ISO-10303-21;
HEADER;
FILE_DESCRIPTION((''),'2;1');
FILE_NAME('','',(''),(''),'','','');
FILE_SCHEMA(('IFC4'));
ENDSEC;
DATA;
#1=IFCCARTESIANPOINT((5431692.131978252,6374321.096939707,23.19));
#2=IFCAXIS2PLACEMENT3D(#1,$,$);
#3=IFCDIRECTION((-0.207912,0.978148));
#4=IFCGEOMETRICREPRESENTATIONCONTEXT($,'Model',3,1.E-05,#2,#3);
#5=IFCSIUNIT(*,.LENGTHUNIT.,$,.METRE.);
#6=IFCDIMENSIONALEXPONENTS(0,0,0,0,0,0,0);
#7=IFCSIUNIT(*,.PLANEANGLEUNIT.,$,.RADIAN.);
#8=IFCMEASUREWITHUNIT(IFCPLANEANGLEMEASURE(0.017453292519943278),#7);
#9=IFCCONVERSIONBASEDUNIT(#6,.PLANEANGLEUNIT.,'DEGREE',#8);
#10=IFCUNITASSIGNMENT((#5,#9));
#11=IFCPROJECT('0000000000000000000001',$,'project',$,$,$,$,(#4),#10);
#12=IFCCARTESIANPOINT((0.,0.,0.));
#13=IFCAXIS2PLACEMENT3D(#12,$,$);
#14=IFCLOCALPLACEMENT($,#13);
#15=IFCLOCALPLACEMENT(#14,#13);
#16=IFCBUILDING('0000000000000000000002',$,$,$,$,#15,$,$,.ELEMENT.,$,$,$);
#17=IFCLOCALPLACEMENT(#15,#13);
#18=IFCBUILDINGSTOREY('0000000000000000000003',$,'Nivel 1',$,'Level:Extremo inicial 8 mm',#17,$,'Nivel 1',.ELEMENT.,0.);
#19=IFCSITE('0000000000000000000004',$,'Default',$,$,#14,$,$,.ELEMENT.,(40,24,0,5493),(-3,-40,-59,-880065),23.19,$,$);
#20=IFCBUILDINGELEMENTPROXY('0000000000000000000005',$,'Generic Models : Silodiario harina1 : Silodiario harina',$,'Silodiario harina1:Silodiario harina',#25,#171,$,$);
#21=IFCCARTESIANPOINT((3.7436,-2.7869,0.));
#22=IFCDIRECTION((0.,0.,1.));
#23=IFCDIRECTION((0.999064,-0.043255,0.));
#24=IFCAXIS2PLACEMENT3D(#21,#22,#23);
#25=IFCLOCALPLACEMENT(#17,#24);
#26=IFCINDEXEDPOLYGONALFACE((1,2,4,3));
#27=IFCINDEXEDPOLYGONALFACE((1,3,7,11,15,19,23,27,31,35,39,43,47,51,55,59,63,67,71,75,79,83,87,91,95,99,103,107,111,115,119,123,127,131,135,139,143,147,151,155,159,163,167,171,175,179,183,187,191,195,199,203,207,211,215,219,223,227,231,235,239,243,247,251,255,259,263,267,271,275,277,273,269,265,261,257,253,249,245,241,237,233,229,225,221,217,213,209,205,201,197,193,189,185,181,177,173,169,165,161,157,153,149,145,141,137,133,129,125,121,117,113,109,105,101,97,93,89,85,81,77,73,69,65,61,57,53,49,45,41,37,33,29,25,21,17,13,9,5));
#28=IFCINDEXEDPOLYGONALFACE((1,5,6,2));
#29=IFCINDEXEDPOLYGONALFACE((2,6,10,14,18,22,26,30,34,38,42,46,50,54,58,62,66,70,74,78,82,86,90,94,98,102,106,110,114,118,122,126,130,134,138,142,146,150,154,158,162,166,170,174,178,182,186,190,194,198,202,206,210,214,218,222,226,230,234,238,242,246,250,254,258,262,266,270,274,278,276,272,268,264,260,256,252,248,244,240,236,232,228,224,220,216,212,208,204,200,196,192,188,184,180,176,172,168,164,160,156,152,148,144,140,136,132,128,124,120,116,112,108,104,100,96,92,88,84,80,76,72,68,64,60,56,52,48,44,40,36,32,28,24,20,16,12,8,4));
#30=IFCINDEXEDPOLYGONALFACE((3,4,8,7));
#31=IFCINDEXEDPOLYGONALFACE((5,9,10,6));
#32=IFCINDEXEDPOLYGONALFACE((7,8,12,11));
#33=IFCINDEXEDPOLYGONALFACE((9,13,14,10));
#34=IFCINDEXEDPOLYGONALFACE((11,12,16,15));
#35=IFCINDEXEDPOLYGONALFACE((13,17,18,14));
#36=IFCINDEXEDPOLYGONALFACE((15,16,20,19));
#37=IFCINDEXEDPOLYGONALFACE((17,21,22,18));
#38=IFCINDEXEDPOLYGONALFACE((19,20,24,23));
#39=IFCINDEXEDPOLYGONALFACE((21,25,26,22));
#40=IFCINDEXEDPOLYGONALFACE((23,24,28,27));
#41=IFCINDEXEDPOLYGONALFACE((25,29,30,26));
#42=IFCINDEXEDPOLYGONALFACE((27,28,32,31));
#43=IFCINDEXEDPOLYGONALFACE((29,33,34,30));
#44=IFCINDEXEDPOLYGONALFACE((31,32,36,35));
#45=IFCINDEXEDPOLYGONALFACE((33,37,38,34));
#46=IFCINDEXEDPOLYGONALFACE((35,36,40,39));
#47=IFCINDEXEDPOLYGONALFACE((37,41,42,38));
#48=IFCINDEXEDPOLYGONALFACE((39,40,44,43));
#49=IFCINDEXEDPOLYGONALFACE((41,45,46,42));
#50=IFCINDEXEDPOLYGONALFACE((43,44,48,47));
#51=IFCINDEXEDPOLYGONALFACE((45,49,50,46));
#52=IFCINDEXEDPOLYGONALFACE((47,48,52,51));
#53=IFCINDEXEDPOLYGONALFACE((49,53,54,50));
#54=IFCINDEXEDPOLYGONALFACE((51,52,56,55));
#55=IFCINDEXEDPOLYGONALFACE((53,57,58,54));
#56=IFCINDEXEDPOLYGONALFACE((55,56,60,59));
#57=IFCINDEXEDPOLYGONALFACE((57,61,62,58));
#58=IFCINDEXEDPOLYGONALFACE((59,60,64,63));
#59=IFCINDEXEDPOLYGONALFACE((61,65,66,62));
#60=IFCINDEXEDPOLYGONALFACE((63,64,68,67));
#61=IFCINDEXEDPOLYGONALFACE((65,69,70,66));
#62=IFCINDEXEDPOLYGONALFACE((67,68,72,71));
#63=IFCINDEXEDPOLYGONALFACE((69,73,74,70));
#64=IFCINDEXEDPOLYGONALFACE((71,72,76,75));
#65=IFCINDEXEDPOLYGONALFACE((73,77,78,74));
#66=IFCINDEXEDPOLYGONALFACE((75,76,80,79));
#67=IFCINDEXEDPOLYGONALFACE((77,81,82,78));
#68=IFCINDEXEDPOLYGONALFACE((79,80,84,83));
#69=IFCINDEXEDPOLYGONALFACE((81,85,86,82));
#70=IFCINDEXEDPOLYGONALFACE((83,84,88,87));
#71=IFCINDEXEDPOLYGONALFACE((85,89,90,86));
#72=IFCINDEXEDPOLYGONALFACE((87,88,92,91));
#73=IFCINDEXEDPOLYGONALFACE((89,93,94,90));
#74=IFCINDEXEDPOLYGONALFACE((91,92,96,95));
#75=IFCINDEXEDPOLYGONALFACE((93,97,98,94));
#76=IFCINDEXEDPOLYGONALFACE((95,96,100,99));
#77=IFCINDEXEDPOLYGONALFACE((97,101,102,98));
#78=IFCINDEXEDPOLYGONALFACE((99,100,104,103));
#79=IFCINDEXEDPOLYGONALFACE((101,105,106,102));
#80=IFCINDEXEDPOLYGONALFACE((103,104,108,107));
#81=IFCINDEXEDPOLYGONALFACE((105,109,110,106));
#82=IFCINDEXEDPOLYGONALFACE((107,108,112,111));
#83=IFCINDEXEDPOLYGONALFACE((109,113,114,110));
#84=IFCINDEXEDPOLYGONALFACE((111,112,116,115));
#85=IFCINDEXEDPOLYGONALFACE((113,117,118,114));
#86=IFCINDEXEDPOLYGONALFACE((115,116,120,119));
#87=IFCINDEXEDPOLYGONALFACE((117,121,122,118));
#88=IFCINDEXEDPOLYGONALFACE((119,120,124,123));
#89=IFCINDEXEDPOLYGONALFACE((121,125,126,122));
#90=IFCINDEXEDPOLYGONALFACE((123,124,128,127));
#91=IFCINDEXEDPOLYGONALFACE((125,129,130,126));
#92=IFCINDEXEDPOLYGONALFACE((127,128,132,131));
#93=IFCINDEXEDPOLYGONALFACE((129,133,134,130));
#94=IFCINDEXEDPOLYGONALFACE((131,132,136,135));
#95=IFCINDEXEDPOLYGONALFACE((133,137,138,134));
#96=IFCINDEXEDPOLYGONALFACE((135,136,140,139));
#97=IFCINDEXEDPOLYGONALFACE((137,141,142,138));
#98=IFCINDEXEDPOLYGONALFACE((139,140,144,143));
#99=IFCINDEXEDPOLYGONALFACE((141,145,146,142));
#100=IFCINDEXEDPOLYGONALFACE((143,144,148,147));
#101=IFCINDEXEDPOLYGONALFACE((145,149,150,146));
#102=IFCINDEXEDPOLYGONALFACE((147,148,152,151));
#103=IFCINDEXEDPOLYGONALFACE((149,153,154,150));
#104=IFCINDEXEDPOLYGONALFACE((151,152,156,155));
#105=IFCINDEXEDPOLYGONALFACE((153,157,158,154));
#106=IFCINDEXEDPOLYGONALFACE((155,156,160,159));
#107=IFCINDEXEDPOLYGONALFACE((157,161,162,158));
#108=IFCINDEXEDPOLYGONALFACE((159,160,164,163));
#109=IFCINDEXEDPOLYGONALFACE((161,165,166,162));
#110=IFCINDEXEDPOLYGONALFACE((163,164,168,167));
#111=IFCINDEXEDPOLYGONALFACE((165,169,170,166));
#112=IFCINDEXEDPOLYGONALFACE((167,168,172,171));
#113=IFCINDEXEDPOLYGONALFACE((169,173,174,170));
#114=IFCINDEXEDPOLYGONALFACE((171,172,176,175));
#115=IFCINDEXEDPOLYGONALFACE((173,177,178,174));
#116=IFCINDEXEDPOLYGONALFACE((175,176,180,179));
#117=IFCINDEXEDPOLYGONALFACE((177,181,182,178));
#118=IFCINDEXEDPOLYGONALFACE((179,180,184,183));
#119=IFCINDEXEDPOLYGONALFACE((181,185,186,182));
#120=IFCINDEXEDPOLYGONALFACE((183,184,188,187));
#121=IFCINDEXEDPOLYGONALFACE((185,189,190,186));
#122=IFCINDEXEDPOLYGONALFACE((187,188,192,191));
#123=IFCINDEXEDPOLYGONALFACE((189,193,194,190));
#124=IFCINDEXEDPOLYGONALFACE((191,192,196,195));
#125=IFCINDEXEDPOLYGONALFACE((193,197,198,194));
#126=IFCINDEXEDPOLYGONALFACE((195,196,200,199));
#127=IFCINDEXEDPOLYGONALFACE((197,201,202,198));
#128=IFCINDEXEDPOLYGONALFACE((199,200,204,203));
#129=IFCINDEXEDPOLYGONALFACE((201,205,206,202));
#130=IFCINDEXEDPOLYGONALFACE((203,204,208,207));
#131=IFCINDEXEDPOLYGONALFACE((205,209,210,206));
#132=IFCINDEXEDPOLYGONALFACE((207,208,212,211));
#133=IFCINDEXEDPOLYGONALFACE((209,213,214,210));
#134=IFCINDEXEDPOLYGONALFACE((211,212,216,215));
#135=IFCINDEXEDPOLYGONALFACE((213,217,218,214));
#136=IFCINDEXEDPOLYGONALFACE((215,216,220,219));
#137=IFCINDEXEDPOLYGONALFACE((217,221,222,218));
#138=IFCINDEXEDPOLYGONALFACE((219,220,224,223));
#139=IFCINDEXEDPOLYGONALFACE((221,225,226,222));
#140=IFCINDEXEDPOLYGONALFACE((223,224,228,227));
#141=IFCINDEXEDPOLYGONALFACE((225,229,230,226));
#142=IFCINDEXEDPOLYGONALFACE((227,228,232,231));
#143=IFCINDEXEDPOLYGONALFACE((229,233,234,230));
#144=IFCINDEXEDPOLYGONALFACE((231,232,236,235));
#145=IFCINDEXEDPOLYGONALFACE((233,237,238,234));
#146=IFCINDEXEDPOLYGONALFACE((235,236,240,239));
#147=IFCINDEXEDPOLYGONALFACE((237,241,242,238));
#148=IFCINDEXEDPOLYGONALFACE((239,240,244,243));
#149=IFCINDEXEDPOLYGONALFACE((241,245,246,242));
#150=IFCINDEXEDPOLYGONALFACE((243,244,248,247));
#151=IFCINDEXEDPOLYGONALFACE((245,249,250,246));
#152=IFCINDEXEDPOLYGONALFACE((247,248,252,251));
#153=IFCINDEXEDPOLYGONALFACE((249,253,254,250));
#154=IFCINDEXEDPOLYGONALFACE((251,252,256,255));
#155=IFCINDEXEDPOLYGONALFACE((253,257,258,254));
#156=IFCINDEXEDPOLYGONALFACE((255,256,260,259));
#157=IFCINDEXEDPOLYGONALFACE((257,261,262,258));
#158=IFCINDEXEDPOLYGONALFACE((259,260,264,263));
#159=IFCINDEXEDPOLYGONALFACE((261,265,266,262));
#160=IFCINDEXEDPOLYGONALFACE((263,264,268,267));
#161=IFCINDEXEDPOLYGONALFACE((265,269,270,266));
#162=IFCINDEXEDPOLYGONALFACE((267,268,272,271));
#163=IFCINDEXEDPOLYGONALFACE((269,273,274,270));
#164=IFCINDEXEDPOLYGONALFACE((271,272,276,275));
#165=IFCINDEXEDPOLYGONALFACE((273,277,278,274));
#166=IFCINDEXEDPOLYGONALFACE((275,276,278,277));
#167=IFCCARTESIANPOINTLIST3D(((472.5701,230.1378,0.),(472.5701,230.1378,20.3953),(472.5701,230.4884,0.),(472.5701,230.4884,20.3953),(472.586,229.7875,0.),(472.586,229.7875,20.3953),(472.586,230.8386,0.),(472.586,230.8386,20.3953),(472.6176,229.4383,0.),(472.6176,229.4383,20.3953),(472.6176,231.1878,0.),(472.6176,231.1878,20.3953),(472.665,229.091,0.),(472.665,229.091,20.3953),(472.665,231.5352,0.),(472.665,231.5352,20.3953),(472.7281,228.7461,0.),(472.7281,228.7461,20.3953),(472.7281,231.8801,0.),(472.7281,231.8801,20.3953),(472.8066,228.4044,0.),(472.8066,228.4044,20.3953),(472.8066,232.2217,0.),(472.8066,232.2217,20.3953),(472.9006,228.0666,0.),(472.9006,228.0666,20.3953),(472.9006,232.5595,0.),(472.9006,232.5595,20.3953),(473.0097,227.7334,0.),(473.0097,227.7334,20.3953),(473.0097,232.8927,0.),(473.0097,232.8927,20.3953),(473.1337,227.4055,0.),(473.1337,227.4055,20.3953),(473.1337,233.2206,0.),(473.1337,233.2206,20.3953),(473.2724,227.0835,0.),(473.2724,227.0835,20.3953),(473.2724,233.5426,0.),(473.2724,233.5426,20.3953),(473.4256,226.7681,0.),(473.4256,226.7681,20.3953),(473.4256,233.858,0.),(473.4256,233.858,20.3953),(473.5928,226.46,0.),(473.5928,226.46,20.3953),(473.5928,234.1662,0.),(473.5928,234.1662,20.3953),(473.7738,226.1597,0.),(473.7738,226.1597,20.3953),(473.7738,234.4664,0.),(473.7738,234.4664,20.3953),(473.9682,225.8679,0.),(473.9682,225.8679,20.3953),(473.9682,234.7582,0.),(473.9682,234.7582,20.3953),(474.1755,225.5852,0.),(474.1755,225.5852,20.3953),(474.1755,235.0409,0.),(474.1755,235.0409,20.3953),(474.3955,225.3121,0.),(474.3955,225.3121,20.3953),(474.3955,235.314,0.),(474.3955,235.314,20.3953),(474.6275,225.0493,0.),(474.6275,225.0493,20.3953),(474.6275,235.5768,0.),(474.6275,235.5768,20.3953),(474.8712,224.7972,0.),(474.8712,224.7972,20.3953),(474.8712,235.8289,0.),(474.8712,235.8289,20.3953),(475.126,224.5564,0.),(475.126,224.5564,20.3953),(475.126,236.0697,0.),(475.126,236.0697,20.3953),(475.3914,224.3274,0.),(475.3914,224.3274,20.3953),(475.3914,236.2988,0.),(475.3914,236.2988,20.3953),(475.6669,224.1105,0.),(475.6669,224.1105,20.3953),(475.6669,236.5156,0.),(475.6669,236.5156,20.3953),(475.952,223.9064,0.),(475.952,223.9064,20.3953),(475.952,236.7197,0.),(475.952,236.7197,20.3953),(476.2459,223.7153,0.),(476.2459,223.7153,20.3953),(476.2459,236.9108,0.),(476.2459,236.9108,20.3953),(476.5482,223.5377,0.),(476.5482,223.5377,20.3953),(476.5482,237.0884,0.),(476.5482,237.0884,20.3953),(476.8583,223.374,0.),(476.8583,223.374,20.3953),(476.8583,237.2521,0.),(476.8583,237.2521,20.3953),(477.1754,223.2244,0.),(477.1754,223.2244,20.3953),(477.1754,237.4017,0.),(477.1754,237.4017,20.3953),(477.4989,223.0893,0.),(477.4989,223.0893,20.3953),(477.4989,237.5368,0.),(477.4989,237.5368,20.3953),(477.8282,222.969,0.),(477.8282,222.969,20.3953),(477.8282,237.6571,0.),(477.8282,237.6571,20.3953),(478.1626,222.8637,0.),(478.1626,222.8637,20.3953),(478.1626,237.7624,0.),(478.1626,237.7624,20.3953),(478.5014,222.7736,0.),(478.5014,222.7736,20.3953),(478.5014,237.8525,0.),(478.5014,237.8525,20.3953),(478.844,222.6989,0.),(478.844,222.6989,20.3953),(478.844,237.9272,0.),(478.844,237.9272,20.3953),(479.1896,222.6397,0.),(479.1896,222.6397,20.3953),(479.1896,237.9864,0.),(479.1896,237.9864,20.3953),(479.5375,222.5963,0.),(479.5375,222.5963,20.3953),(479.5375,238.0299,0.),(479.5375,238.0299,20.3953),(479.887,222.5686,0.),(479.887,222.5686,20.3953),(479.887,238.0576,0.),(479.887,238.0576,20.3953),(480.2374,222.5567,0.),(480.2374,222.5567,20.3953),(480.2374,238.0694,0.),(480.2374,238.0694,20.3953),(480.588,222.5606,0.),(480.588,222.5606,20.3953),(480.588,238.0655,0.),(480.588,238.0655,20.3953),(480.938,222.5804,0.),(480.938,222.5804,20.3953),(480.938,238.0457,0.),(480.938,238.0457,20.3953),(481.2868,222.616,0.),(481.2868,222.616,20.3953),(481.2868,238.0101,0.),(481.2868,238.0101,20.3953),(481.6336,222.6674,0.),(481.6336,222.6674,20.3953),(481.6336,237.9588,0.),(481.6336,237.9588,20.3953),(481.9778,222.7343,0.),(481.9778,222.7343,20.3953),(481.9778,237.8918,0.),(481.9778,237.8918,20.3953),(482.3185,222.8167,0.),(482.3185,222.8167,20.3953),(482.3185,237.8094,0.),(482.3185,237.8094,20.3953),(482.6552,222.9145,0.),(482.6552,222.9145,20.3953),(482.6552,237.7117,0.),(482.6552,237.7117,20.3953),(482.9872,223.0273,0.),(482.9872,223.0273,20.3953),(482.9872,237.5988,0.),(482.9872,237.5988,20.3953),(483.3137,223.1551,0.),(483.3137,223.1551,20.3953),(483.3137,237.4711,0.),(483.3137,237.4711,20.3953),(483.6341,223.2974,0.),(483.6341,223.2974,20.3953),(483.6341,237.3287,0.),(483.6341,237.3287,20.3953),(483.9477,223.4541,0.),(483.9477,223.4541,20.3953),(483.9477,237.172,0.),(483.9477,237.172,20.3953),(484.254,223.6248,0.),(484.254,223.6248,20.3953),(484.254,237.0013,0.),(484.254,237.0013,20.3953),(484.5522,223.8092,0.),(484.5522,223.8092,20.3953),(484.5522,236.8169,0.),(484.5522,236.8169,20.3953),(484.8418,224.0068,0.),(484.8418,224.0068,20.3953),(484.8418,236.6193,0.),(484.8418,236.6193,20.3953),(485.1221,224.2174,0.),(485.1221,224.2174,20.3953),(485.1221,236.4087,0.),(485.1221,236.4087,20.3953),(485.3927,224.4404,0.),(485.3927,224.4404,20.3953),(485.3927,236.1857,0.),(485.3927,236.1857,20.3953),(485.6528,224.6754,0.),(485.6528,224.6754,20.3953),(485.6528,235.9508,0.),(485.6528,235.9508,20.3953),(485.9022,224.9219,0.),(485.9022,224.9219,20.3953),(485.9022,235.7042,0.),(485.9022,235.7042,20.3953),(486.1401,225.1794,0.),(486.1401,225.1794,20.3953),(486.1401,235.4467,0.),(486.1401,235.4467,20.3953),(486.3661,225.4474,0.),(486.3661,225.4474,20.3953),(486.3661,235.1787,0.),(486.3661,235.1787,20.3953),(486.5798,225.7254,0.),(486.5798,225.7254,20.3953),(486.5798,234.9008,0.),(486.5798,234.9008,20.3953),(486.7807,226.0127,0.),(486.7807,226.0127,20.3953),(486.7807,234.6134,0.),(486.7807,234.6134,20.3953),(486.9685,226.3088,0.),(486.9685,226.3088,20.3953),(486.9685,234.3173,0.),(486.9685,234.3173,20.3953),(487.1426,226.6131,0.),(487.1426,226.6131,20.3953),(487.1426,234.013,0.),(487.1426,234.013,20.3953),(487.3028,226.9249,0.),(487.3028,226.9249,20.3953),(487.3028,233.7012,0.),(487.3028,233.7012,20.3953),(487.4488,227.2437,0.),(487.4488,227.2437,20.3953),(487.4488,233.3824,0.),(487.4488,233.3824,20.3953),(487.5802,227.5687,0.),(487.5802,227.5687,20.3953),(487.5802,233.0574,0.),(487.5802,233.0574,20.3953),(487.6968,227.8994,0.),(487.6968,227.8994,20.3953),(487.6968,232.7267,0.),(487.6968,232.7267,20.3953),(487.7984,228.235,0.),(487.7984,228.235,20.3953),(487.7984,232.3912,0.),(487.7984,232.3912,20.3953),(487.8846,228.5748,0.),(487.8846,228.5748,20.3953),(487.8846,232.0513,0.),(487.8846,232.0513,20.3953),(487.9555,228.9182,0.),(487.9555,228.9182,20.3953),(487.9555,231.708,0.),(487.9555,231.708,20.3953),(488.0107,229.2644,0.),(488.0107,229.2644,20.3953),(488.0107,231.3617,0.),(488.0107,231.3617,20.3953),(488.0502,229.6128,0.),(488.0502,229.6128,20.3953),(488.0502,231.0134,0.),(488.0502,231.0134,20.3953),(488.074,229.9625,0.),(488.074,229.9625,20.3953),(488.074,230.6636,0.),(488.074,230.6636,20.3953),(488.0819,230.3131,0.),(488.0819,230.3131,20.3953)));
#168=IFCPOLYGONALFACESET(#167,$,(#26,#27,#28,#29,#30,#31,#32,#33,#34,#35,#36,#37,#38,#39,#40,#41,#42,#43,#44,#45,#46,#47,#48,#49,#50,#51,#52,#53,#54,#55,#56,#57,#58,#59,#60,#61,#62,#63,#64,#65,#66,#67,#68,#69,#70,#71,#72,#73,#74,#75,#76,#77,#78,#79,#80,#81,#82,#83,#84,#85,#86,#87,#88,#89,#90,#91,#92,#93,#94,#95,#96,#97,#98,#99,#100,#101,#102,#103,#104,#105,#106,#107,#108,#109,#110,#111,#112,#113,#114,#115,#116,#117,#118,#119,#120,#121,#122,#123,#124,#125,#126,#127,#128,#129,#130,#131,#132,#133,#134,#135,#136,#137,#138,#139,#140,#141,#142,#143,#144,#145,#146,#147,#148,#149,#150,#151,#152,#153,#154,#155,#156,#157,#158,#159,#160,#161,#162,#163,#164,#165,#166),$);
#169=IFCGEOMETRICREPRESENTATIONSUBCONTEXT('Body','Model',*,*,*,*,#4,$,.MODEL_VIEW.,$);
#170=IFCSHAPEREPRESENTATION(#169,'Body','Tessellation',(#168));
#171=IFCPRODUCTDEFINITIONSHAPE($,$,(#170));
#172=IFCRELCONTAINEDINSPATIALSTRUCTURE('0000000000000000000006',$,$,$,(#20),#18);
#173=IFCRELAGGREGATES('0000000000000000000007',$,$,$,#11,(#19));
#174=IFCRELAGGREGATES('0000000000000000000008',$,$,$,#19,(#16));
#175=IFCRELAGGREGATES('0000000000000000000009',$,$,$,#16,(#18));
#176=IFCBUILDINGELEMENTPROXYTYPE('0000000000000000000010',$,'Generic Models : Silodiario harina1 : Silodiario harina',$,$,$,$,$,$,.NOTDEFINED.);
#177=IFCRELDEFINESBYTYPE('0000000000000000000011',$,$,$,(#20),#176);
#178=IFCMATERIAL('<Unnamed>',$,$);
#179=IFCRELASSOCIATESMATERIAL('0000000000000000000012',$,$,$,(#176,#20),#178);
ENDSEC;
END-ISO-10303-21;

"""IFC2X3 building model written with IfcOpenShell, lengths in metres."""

from ifc_helpers import new_model, entity, si_unit, converted_unit, direction, frame, origin, origin_2d_with_axis, place, context, subcontext, project, spatial, circle, extrude, source, transform, mapped, material, type_object, type_shapes, element, save


model = new_model("IFC2X3")

# Units and contexts
model_context = context("Model", 3, precision=1e-05, world=frame((5431692.131978252, 6374321.096939707, 23.19)), true_north=direction((-0.207912, 0.978148)))
body_context = subcontext(model_context, "Body", "Model", "MODEL_VIEW")
ifc_project = project(units=[si_unit("LENGTHUNIT", "METRE"), converted_unit("PLANEANGLEUNIT", "DEGREE", entity("IfcPlaneAngleMeasure", 0.017453292519943278), si_unit("PLANEANGLEUNIT", "RADIAN"), dimensions=[0, 0, 0, 0, 0, 0, 0])], contexts=[model_context])

# Site, building, storey
site_placement = place(None, origin())
site = spatial("IfcSite", under=ifc_project, at=site_placement, Name="Default", CompositionType="ELEMENT", RefLatitude=(40, 24, 0, 5493), RefLongitude=(-3, -40, -59, -880065), RefElevation=23.19)
building_placement = place(site_placement, origin())
building = spatial("IfcBuilding", under=site, at=building_placement, CompositionType="ELEMENT")
storey_placement = place(building_placement, origin())
storey = spatial("IfcBuildingStorey", under=building, at=storey_placement, Name="Nivel 1", ObjectType="Level:Extremo inicial 8 mm", LongName="Nivel 1", CompositionType="ELEMENT", Elevation=0.0)

# Building element proxy
ifc_material_1 = material(Name="<Unnamed>")
building_element_proxy_type_1 = type_object("IfcBuildingElementProxyType", Name="Generic Models : Silodiario harina1 : Silodiario harina", PredefinedType="NOTDEFINED", material=ifc_material_1)
shared_shape_1 = source(origin(), body_context, "Body", "SweptSolid", [
    extrude(circle(Radius=7.7569, at=origin_2d_with_axis()), frame((480.325, 230.3131, 0.0)), (0.0, 0.0, 1.0), 20.3953),
])
type_shapes(building_element_proxy_type_1, [shared_shape_1])
proxy_1_placement = place(storey_placement, frame((3.7436, -2.7869, 0.0), z_axis=(0.0, 0.0, 1.0), x_axis=(0.999064, -0.043255, 0.0)))
element("IfcBuildingElementProxy", 1, at=proxy_1_placement, inside=storey, type_object=building_element_proxy_type_1, material=ifc_material_1, Name="Generic Models : Silodiario harina1 : Silodiario harina", ObjectType="Silodiario harina1:Silodiario harina", context=body_context, shape_type="MappedRepresentation", body=[
    mapped(shared_shape_1, transform((0.0, 0.0, 0.0), scale=1.0)),
])

save(model, "model.ifc")
